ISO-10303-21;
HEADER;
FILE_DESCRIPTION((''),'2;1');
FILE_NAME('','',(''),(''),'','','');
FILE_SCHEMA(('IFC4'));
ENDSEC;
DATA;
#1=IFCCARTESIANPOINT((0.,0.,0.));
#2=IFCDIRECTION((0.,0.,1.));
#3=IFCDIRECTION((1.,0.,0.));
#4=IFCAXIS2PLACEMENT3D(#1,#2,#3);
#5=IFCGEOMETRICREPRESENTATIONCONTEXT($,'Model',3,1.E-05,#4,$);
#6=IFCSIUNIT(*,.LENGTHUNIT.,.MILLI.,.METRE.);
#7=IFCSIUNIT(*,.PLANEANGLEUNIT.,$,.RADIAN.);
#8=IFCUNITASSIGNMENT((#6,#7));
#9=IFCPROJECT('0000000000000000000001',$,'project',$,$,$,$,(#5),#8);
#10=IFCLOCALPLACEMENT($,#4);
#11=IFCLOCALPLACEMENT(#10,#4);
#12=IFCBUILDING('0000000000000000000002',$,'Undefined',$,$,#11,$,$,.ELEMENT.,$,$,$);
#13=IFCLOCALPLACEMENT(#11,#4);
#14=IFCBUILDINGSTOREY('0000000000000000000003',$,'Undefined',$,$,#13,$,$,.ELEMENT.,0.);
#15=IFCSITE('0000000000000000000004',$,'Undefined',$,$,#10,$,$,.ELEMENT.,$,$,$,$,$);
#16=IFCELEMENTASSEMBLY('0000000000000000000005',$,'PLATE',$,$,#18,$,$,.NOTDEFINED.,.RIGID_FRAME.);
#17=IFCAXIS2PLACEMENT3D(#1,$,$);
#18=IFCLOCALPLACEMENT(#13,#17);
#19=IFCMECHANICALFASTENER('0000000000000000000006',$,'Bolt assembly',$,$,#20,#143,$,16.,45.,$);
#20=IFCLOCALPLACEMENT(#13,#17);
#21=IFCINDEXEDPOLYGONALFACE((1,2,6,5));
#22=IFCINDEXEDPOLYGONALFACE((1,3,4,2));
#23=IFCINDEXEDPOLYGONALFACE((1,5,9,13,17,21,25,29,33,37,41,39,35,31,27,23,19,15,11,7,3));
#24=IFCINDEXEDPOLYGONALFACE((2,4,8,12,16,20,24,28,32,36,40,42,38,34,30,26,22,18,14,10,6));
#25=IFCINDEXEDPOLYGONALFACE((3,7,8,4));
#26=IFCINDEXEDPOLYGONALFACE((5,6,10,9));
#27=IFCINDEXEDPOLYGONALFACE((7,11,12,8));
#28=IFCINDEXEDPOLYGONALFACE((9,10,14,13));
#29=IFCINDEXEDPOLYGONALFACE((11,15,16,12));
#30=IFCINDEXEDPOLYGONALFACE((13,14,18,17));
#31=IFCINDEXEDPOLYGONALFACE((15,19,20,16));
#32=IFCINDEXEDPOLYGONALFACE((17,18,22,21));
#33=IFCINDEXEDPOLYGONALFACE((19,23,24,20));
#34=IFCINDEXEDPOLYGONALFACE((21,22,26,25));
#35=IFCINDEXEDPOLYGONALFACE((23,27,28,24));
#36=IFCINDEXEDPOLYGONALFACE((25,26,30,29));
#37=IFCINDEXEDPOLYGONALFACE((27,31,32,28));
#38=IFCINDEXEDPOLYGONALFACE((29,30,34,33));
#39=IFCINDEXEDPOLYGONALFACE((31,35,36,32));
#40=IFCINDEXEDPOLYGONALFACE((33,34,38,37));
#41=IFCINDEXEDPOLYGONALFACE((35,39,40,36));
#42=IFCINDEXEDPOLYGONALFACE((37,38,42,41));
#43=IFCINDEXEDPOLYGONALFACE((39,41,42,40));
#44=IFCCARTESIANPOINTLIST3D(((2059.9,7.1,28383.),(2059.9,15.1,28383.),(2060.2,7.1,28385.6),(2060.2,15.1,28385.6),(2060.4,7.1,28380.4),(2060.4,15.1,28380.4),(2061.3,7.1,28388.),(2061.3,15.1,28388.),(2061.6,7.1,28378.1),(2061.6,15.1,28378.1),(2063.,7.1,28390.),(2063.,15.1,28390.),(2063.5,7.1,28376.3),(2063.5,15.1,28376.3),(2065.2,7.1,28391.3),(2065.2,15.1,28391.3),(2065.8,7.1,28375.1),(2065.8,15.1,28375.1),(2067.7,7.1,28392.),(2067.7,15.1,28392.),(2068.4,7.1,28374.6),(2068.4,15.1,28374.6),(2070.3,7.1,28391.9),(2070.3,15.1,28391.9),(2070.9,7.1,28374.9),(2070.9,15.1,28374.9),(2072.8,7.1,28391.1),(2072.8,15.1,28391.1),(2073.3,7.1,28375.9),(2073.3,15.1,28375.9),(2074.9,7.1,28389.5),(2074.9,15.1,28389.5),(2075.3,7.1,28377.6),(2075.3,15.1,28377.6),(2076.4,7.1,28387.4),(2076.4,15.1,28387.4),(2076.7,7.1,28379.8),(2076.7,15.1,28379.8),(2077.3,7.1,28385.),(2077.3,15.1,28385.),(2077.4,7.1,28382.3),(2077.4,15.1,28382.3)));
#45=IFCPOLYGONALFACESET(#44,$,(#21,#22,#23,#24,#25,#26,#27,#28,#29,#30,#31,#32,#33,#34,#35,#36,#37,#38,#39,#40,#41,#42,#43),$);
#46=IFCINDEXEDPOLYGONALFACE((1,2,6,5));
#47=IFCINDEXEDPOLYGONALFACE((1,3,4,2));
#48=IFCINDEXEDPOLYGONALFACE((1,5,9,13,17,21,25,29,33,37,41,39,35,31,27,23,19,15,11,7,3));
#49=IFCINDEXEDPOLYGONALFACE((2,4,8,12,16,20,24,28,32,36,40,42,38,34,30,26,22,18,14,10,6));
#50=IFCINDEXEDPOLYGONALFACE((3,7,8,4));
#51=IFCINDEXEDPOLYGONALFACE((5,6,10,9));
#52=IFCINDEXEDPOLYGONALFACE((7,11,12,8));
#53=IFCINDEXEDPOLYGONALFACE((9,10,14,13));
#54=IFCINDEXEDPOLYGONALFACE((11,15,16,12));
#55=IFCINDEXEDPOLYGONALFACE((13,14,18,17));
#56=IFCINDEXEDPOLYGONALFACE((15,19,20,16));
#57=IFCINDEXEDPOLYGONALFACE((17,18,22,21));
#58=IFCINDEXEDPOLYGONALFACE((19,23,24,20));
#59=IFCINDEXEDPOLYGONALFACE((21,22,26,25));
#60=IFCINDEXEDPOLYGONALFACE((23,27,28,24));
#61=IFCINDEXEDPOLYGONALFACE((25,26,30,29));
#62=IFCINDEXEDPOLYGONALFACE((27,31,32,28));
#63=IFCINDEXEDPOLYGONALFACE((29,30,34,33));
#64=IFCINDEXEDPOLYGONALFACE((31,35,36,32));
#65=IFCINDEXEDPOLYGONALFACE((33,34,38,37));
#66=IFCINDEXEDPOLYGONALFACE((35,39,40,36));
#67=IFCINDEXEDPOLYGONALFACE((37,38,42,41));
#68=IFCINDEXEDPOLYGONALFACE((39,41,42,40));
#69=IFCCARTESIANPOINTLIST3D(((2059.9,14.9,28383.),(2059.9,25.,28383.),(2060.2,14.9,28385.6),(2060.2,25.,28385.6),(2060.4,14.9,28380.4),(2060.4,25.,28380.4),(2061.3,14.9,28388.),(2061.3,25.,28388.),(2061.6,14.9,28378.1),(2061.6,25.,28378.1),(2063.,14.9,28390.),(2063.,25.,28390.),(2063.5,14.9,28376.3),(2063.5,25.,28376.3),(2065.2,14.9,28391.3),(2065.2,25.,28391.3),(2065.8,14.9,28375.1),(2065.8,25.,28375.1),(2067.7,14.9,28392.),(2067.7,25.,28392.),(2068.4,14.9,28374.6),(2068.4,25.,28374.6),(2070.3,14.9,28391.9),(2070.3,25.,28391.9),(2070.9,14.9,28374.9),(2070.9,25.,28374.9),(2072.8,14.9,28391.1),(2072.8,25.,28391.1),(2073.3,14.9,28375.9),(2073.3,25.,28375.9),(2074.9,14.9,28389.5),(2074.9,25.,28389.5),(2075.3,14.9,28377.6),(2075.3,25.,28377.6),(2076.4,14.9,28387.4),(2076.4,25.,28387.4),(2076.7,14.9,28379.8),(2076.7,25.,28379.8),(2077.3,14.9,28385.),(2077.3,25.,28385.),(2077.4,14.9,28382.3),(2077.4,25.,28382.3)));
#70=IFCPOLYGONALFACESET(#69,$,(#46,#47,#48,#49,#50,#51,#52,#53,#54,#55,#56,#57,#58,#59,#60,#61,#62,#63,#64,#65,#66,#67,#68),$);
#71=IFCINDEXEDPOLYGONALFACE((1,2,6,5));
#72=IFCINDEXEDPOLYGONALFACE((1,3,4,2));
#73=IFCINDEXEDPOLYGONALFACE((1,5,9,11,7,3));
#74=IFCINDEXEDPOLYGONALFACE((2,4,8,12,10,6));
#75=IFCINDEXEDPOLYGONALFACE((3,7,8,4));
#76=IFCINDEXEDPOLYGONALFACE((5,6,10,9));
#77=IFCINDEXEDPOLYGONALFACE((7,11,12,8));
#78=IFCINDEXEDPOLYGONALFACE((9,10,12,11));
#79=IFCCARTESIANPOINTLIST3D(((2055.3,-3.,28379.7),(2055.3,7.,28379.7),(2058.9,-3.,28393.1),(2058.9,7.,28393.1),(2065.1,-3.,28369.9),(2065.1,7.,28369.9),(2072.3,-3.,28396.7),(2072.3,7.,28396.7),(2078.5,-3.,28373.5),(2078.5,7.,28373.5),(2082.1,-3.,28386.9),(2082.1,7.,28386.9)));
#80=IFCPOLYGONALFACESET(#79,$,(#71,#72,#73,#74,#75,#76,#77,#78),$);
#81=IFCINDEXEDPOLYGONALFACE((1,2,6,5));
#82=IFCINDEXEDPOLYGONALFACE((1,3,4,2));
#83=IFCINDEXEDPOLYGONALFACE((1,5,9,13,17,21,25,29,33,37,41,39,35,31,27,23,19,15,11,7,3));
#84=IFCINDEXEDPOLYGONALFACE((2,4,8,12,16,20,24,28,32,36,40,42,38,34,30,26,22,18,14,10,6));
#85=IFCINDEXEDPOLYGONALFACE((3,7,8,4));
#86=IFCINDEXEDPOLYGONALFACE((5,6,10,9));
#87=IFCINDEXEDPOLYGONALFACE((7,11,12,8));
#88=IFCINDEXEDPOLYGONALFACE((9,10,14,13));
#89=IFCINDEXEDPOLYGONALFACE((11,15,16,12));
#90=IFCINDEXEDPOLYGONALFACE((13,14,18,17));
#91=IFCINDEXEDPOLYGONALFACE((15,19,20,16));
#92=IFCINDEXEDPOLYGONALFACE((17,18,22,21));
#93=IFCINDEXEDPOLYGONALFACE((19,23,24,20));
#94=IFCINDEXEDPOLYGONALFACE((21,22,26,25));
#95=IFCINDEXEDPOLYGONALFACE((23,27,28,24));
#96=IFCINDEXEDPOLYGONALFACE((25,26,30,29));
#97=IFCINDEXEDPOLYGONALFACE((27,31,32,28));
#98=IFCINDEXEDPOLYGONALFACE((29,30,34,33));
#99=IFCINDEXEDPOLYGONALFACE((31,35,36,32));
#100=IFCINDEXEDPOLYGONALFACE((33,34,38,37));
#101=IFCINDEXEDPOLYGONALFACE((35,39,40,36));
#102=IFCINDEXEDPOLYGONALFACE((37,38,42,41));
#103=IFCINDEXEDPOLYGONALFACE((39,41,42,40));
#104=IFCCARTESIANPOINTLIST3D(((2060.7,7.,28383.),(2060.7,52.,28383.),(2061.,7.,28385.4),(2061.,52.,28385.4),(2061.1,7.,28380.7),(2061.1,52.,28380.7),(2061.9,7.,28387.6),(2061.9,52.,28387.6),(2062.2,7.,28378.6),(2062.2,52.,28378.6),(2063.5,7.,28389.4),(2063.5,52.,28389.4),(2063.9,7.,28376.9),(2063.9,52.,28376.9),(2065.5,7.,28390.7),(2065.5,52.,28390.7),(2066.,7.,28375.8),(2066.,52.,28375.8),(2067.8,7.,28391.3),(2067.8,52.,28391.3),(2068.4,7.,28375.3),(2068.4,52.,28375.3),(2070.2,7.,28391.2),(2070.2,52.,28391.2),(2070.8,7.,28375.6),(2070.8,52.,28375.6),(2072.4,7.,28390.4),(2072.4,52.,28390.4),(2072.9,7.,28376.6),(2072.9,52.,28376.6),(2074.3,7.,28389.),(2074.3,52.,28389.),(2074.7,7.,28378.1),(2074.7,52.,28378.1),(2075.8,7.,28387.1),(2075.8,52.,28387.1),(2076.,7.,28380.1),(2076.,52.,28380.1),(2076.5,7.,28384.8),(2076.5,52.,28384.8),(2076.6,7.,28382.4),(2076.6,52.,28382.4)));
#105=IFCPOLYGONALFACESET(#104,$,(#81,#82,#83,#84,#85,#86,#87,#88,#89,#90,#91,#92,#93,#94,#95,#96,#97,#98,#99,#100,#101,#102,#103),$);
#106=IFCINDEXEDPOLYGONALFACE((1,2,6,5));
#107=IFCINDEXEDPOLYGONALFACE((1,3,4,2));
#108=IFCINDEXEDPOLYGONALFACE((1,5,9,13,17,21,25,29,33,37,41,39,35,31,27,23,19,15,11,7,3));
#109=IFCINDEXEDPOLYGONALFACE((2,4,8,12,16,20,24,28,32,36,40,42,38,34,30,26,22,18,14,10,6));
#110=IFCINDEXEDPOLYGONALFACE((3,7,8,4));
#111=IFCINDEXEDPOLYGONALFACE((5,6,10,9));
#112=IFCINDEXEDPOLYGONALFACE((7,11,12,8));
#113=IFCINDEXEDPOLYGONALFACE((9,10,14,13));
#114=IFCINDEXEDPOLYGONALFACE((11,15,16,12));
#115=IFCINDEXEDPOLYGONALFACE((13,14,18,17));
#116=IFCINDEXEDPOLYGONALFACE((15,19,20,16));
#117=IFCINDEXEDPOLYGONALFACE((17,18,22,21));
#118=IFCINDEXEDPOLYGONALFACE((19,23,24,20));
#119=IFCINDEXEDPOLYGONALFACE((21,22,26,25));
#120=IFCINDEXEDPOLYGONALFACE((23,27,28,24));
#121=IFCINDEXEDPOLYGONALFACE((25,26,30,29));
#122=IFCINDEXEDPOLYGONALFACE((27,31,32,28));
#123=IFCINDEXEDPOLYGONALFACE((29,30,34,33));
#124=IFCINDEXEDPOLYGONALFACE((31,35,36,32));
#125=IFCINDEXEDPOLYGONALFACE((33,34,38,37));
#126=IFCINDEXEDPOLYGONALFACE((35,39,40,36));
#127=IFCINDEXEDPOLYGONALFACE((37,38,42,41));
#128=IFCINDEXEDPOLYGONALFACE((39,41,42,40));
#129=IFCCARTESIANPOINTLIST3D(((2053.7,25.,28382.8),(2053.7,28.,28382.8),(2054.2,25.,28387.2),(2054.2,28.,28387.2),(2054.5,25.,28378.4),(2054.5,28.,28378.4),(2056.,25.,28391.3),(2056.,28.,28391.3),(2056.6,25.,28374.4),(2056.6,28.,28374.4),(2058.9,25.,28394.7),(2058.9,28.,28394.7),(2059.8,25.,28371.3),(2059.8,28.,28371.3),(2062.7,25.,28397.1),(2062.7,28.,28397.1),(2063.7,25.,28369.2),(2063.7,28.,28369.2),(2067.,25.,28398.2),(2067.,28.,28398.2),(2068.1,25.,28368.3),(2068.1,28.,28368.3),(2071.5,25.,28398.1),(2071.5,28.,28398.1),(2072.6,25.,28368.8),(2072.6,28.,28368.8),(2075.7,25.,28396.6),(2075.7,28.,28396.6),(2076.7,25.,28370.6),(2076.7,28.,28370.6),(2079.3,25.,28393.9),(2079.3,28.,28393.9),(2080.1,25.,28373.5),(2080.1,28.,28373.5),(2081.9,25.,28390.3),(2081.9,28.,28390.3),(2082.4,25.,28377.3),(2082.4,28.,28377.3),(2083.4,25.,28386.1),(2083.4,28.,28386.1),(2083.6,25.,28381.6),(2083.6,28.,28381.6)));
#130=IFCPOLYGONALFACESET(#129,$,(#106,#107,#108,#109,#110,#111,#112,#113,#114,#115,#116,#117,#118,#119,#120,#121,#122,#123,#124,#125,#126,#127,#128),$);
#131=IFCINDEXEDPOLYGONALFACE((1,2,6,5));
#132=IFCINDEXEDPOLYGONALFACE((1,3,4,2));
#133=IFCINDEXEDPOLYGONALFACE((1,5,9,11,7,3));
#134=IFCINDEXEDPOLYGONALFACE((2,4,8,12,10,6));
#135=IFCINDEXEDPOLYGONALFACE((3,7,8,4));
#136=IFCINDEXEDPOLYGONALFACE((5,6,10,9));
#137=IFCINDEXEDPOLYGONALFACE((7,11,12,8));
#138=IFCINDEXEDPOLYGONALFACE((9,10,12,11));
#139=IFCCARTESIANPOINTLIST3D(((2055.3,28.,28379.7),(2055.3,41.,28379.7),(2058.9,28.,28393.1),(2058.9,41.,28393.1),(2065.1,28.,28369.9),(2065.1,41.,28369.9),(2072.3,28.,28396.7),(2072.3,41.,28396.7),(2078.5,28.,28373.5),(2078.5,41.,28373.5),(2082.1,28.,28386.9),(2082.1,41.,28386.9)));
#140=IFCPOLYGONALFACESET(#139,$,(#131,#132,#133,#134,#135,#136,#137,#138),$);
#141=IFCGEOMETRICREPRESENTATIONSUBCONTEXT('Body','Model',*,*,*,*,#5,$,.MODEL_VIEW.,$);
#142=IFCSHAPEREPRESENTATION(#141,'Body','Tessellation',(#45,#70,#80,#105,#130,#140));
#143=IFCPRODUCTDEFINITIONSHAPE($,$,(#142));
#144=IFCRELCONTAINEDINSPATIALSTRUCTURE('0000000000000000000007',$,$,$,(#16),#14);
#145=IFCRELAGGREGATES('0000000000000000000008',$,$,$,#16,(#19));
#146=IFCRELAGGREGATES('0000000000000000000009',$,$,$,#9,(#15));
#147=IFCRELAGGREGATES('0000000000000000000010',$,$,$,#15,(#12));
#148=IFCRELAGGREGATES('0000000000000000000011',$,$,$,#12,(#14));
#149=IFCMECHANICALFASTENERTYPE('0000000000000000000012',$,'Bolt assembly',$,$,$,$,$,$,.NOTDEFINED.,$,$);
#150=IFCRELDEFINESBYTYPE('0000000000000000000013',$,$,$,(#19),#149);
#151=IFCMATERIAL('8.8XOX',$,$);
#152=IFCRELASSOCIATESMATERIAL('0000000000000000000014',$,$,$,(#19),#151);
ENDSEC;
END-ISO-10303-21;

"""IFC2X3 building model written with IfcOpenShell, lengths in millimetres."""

from ifc_helpers import new_model, si_unit, frame, origin_with_axes, origin_2d_with_axis, place, context, subcontext, project, spatial, polyline, circle, outline, extrude, source, transform, mapped, material, type_object, element, aggregate, save


model = new_model("IFC2X3")

# Units and contexts
model_context = context("Model", 3, precision=1e-05, world=origin_with_axes())
body_context = subcontext(model_context, "Body", "Model", "MODEL_VIEW")
ifc_project = project(units=[si_unit("LENGTHUNIT", "METRE", prefix="MILLI"), si_unit("PLANEANGLEUNIT", "RADIAN")], contexts=[model_context])

# Site, building, storey
site_placement = place(None, origin_with_axes())
site = spatial("IfcSite", under=ifc_project, at=site_placement, Name="Undefined", CompositionType="ELEMENT")
building_placement = place(site_placement, origin_with_axes())
building = spatial("IfcBuilding", under=site, at=building_placement, Name="Undefined", CompositionType="ELEMENT")
storey_placement = place(building_placement, origin_with_axes())
storey = spatial("IfcBuildingStorey", under=building, at=storey_placement, Name="Undefined", CompositionType="ELEMENT", Elevation=0.0)

# Element assembly
assembly_1_placement = place(storey_placement, origin_with_axes())
assembly_1 = element("IfcElementAssembly", 1, at=assembly_1_placement, inside=storey, Name="PLATE", AssemblyPlace="NOTDEFINED", PredefinedType="RIGID_FRAME")

# Mechanical fastener
ifc_material_1 = material(Name="8.8XOX")
mechanical_fastener_type = type_object("IfcMechanicalFastenerType", Name="Bolt assembly")
shared_shape_1 = source(origin_with_axes(), body_context, "Body", "SweptSolid", [
    extrude(circle(Radius=8.8, at=origin_2d_with_axis()), frame((0.0, 7.1, 0.0), z_axis=(0.0, 1.0, 0.0), x_axis=(1.0, 0.0, 0.0)), (0.0, 0.0, 1.0), 8.0),
    extrude(circle(Radius=8.8, at=origin_2d_with_axis()), frame((0.0, 14.9, 0.0), z_axis=(0.0, 1.0, 0.0), x_axis=(1.0, 0.0, 0.0)), (0.0, 0.0, 1.0), 10.1),
    extrude(outline(polyline([(12.0, -6.9), (12.0, 6.9), (0.0, 13.9), (-12.0, 6.9), (-12.0, -6.9), (0.0, -13.9), (12.0, -6.9)])), frame((0.0, -3.0, 0.0), z_axis=(0.0, 1.0, 0.0), x_axis=(1.0, 0.0, 0.0)), (0.0, 0.0, 1.0), 10.0),
    extrude(circle(Radius=8.0, at=origin_2d_with_axis()), frame((0.0, 7.0, 0.0), z_axis=(0.0, 1.0, 0.0), x_axis=(1.0, 0.0, 0.0)), (0.0, 0.0, 1.0), 45.0),
    extrude(circle(Radius=15.0, at=origin_2d_with_axis()), frame((0.0, 25.0, 0.0), z_axis=(0.0, 1.0, 0.0), x_axis=(1.0, 0.0, 0.0)), (0.0, 0.0, 1.0), 3.0),
    extrude(outline(polyline([(12.0, -6.9), (12.0, 6.9), (0.0, 13.9), (-12.0, 6.9), (-12.0, -6.9), (0.0, -13.9), (12.0, -6.9)])), frame((0.0, 28.0, 0.0), z_axis=(0.0, 1.0, 0.0), x_axis=(1.0, 0.0, 0.0)), (0.0, 0.0, 1.0), 13.0),
])
mechanical_fastener_1_placement = place(assembly_1_placement, frame((2068.7, 0.0, 28383.3), z_axis=(-0.707107, 0.0, 0.707107), x_axis=(0.707107, 0.0, 0.707107)))
mechanical_fastener_1 = element("IfcMechanicalFastener", 2, at=mechanical_fastener_1_placement, type_object=mechanical_fastener_type, material=ifc_material_1, Name="Bolt assembly", NominalDiameter=16.0, NominalLength=45.0, context=body_context, shape_type="MappedRepresentation", body=[
    mapped(shared_shape_1, transform((0.0, 0.0, 0.0))),
])
aggregate(assembly_1, [mechanical_fastener_1])

save(model, "model.ifc")
